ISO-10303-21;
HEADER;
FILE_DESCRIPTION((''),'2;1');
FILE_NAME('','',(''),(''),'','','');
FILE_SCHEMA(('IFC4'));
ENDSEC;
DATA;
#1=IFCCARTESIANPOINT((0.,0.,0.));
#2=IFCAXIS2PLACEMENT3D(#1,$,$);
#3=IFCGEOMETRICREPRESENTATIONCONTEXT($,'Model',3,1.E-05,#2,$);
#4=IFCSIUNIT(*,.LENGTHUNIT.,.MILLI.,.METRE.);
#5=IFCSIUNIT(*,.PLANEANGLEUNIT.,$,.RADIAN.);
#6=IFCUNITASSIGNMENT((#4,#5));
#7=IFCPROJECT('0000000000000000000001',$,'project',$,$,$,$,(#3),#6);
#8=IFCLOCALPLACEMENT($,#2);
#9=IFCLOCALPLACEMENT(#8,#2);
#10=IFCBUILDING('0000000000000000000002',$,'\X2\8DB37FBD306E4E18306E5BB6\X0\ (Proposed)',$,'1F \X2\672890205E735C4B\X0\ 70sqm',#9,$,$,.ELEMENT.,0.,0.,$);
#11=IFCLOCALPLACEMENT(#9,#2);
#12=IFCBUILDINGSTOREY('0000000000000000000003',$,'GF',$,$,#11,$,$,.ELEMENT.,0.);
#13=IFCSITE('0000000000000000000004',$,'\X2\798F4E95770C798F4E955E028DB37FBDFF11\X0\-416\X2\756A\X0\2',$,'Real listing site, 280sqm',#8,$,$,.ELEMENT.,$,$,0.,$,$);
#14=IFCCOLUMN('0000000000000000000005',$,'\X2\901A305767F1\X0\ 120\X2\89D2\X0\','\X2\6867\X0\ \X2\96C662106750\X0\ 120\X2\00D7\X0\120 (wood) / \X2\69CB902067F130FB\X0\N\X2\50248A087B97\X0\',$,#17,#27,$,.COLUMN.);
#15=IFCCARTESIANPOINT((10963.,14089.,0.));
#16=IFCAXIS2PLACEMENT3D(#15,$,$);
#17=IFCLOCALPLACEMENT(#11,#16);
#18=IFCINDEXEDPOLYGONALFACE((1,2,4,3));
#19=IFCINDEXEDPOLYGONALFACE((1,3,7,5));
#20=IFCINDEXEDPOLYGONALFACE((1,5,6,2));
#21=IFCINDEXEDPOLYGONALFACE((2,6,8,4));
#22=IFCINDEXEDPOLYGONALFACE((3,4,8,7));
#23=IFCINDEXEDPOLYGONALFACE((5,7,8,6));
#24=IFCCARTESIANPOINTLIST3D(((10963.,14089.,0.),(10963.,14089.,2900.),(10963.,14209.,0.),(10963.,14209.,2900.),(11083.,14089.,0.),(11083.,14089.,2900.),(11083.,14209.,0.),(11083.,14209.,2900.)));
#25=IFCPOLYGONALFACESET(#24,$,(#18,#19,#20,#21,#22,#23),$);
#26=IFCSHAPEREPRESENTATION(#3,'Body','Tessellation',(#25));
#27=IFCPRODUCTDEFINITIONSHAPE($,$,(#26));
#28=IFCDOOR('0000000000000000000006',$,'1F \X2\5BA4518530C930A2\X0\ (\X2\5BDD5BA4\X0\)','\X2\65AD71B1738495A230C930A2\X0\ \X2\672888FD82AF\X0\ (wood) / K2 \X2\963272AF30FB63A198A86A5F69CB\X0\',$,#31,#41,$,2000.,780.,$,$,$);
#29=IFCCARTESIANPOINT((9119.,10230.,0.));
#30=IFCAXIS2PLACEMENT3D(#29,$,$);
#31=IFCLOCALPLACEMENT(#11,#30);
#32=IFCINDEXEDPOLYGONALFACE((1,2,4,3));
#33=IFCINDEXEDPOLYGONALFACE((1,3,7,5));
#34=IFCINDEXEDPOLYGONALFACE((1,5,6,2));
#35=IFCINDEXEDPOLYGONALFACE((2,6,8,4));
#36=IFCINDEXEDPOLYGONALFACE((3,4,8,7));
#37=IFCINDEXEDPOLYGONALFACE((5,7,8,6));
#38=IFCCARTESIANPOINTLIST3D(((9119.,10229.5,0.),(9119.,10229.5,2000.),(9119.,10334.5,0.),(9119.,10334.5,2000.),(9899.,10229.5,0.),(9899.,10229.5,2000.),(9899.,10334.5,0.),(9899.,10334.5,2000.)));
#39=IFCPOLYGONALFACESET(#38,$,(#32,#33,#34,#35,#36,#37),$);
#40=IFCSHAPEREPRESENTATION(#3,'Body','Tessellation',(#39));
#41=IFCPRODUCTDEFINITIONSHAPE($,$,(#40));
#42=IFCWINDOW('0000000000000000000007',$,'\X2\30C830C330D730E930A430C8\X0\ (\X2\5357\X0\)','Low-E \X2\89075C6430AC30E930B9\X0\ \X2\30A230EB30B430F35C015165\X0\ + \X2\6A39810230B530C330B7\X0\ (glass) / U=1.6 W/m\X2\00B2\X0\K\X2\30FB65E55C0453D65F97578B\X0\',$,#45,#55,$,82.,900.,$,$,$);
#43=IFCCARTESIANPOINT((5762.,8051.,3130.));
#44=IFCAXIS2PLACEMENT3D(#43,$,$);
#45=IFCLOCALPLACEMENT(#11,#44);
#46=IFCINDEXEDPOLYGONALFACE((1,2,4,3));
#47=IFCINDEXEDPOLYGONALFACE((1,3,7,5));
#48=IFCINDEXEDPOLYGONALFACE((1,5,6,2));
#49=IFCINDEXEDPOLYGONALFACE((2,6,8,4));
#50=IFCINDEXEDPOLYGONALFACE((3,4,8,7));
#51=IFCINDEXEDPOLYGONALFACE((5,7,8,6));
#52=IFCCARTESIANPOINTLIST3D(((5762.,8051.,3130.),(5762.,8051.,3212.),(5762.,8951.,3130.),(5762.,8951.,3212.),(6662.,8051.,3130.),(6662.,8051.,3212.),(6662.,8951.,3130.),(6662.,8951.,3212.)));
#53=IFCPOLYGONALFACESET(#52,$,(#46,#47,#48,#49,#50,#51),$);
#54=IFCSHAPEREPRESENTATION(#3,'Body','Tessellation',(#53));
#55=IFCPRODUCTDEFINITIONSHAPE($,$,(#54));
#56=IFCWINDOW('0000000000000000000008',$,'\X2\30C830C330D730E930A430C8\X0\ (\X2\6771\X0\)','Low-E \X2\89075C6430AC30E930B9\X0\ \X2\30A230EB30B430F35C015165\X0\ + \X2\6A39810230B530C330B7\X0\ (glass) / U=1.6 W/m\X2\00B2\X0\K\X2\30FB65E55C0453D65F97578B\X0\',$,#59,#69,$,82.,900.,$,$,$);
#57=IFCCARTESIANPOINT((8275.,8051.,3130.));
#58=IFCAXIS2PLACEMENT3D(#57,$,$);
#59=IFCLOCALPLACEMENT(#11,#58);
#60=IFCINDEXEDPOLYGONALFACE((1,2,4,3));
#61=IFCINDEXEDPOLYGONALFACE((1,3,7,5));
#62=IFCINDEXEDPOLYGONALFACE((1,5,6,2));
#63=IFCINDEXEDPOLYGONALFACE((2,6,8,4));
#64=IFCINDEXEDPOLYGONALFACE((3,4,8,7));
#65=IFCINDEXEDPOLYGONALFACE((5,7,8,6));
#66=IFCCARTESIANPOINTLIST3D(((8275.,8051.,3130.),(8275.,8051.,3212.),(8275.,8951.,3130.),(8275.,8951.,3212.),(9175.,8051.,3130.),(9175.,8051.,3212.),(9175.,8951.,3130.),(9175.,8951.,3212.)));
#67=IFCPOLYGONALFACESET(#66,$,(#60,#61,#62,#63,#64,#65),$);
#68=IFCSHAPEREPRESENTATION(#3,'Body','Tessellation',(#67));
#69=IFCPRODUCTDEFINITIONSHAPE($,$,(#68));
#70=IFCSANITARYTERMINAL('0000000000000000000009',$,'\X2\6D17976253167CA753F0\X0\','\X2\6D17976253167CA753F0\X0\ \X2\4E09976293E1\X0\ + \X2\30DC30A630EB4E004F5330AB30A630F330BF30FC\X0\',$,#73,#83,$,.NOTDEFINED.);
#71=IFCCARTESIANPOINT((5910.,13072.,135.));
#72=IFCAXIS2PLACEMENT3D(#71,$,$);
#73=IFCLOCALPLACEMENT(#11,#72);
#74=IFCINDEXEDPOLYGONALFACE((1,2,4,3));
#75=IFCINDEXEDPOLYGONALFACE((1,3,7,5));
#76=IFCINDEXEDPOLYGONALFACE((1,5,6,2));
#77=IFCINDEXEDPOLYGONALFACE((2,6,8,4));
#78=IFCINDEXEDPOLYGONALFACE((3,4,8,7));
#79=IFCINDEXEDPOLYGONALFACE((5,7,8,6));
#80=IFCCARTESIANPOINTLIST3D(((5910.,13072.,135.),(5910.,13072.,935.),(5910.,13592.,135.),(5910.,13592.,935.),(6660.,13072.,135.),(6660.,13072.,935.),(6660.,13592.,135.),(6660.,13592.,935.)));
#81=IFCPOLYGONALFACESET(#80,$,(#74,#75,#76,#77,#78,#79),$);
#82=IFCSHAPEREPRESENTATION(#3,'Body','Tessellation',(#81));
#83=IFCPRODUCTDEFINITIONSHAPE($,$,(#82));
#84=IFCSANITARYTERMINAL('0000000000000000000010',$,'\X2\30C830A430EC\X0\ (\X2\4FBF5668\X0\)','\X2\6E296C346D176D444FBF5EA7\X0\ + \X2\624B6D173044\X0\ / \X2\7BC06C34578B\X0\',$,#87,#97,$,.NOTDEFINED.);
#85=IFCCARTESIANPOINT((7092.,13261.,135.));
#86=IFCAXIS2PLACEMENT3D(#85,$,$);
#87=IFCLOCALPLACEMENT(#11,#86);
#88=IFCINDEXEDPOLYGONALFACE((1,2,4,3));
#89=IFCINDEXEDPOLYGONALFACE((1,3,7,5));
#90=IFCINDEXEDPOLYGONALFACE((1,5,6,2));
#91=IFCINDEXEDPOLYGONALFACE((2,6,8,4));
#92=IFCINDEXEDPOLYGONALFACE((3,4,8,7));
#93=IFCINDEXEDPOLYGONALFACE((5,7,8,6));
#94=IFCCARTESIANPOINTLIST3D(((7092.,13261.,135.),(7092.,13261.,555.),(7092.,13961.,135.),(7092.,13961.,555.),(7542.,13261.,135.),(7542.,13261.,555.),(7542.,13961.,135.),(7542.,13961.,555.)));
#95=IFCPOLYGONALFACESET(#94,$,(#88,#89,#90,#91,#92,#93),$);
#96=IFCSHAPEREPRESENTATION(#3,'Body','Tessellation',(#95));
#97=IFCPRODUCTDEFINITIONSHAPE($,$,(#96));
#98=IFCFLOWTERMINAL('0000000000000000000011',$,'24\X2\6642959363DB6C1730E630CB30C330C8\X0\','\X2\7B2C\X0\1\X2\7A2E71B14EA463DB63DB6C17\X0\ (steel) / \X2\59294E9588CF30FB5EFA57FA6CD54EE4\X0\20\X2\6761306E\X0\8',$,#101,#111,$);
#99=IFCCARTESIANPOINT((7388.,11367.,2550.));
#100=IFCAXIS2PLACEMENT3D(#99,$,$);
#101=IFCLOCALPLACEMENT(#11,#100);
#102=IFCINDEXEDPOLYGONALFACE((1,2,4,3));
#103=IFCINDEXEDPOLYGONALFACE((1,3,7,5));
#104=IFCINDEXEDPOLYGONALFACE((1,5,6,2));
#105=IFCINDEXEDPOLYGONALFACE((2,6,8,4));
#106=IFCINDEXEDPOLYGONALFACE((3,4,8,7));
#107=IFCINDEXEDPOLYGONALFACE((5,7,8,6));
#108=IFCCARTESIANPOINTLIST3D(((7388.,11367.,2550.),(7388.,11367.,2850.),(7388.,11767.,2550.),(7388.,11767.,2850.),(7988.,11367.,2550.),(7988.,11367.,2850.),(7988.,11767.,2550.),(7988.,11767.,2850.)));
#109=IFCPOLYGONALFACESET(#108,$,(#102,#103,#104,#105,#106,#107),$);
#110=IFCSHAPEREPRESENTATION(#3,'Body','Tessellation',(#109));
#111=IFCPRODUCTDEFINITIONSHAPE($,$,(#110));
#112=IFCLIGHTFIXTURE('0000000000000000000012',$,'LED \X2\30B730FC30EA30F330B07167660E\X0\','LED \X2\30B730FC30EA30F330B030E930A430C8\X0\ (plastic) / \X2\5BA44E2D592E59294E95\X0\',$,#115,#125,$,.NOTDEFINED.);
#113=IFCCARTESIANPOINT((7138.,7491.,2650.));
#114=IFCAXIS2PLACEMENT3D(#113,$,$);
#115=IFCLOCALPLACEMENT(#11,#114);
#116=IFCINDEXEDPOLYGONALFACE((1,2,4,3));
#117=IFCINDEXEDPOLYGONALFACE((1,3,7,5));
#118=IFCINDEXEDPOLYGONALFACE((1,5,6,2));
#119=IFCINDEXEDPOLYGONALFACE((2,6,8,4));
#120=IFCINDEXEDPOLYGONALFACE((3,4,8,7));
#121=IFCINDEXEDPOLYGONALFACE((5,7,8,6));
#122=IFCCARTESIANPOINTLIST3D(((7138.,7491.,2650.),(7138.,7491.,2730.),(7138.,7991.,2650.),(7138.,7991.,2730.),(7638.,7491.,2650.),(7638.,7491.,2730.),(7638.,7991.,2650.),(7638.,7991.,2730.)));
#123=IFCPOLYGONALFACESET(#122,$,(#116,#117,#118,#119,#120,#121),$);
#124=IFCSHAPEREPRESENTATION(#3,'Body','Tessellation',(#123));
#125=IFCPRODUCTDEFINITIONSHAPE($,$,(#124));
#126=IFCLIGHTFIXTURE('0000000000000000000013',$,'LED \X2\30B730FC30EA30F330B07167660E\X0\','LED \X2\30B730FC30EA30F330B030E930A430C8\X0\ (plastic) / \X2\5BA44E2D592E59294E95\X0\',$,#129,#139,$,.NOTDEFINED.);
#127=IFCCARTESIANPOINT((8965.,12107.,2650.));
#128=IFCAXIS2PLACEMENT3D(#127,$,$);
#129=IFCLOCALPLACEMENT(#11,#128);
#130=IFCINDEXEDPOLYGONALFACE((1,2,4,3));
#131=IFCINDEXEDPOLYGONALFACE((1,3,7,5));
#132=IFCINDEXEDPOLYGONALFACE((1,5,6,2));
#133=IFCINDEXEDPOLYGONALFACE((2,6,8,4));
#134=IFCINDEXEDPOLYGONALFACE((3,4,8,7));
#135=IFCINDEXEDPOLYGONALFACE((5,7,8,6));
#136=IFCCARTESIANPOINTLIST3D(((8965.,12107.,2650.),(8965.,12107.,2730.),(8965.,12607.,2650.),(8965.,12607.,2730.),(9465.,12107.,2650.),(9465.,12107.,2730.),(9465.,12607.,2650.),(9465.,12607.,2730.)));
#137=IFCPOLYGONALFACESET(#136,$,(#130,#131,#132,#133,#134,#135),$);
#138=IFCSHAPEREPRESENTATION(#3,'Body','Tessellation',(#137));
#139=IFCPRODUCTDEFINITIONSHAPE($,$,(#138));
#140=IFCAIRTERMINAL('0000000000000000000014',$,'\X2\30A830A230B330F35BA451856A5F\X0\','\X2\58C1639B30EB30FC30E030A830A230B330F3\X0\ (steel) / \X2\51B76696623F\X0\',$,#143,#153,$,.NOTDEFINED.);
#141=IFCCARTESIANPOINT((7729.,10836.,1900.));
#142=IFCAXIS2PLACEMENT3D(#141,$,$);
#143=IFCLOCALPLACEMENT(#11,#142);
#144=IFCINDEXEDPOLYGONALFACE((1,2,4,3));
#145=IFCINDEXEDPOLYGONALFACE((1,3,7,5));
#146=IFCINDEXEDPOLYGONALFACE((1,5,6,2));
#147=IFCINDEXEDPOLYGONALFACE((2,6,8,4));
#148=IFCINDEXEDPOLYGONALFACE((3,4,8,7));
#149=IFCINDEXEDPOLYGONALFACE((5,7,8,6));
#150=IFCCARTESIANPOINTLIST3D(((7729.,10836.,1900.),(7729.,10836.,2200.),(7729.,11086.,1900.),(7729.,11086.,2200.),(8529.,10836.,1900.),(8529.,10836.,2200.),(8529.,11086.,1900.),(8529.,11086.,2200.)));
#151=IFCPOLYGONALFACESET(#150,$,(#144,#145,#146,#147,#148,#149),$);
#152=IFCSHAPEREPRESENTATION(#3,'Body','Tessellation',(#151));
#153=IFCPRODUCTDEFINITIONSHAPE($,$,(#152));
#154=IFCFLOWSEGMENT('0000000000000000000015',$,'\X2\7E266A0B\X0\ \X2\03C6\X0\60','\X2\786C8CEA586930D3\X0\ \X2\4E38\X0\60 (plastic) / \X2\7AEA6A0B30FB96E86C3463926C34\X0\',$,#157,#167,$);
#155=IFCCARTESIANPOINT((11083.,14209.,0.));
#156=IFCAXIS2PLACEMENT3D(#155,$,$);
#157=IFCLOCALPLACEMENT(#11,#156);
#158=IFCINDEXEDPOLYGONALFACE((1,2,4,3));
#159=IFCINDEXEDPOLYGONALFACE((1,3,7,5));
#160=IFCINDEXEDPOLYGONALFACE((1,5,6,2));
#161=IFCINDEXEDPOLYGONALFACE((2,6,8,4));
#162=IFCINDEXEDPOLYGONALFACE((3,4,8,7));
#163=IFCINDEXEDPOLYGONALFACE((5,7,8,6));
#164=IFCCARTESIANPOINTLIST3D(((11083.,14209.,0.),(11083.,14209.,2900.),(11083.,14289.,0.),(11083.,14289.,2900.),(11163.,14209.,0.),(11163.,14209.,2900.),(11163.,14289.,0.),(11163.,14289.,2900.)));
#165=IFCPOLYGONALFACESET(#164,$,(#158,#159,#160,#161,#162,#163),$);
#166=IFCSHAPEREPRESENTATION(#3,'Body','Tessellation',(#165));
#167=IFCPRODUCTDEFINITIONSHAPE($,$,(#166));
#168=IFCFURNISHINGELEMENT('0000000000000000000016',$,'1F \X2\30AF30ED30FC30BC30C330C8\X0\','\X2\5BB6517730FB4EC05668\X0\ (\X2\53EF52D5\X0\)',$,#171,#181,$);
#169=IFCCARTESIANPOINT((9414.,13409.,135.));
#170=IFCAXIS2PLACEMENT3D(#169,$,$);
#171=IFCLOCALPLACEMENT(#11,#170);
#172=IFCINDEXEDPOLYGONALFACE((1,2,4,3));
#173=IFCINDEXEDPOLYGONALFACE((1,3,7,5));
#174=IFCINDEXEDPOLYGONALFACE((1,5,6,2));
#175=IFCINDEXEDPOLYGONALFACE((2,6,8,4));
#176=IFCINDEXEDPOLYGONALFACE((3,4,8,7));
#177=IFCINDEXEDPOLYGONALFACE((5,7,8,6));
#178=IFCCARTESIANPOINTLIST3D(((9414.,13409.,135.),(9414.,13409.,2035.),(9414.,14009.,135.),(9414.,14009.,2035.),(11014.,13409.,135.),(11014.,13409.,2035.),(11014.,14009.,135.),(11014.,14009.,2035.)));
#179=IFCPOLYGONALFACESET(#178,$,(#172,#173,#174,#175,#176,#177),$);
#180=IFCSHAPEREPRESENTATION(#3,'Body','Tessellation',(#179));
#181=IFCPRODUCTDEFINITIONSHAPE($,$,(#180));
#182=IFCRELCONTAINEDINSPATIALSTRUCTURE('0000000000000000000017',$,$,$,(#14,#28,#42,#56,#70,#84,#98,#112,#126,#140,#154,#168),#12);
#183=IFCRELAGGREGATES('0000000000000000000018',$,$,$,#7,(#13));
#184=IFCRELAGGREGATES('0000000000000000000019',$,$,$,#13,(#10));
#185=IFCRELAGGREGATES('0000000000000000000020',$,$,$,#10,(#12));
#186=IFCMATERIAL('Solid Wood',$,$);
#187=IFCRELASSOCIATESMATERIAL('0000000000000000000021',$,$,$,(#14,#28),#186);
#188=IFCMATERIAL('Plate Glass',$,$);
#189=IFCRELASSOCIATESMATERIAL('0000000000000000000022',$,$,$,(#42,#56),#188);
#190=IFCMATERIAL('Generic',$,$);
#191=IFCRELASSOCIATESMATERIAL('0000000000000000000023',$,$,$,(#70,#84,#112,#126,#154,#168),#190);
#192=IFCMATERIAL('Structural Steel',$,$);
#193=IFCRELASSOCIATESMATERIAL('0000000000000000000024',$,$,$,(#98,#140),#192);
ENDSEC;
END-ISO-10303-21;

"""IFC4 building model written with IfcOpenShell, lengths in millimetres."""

from ifc_helpers import new_model, si_unit, frame, frame_2d, origin, place, context, project, spatial, rectangle, extrude, material, element, save


model = new_model("IFC4")

# Units and contexts
model_context = context("Model", 3, precision=1e-05, world=origin())
ifc_project = project(units=[si_unit("LENGTHUNIT", "METRE", prefix="MILLI"), si_unit("PLANEANGLEUNIT", "RADIAN")], contexts=[model_context])

# Site, building, storey
site_placement = place(None, origin())
site = spatial("IfcSite", under=ifc_project, at=site_placement, Name="福井県福井市足羽１-416番2", ObjectType="Real listing site, 280sqm", CompositionType="ELEMENT", RefElevation=0.0)
building_placement = place(site_placement, origin())
building = spatial("IfcBuilding", under=site, at=building_placement, Name="足羽の丘の家 (Proposed)", ObjectType="1F 木造平屋 70sqm", CompositionType="ELEMENT", ElevationOfRefHeight=0.0, ElevationOfTerrain=0.0)
storey_placement = place(building_placement, origin())
storey = spatial("IfcBuildingStorey", under=building, at=storey_placement, Name="GF", CompositionType="ELEMENT", Elevation=0.0)

# Column
ifc_material_1 = material(Name="Solid Wood")
column_1_placement = place(storey_placement, frame((10963.0, 14089.0, 0.0)))
element("IfcColumn", 1, at=column_1_placement, inside=storey, material=ifc_material_1, Name="通し柱 120角", Description="桧 集成材 120×120 (wood) / 構造柱・N値計算", PredefinedType="COLUMN", context=model_context, shape_type="SweptSolid", body=[
    extrude(rectangle(XDim=120.0, YDim=120.0, at=frame_2d((60.0, 60.0))), frame((10963.0, 14089.0, 0.0)), (0.0, 0.0, 1.0), 2900.0),
])

# Door
door_placement = place(storey_placement, frame((9119.0, 10230.0, 0.0)))
element("IfcDoor", 2, at=door_placement, inside=storey, material=ifc_material_1, Name="1F 室内ドア (寝室)", Description="断熱玄関ドア 木製芯 (wood) / K2 防犯・採風機構", OverallHeight=2000.0, OverallWidth=780.0, context=model_context, shape_type="SweptSolid", body=[
    extrude(rectangle(XDim=780.0, YDim=105.0, at=frame_2d((390.0, 52.0))), frame((9119.0, 10230.0, 0.0)), (0.0, 0.0, 1.0), 2000.0),
])

# Windows
ifc_material_2 = material(Name="Plate Glass")
window_1_placement = place(storey_placement, frame((5762.0, 8051.0, 3130.0)))
element("IfcWindow", 3, at=window_1_placement, inside=storey, material=ifc_material_2, Name="トップライト (南)", Description="Low-E 複層ガラス アルゴン封入 + 樹脂サッシ (glass) / U=1.6 W/m²K・日射取得型", OverallHeight=82.0, OverallWidth=900.0, context=model_context, shape_type="SweptSolid", body=[
    extrude(rectangle(XDim=900.0, YDim=900.0, at=frame_2d((450.0, 450.0))), frame((5762.0, 8051.0, 3130.0)), (0.0, 0.0, 1.0), 82.0),
])
window_2_placement = place(storey_placement, frame((8275.0, 8051.0, 3130.0)))
element("IfcWindow", 4, at=window_2_placement, inside=storey, material=ifc_material_2, Name="トップライト (東)", Description="Low-E 複層ガラス アルゴン封入 + 樹脂サッシ (glass) / U=1.6 W/m²K・日射取得型", OverallHeight=82.0, OverallWidth=900.0, context=model_context, shape_type="SweptSolid", body=[
    extrude(rectangle(XDim=900.0, YDim=900.0, at=frame_2d((450.0, 450.0))), frame((8275.0, 8051.0, 3130.0)), (0.0, 0.0, 1.0), 82.0),
])

# Sanitary terminals
ifc_material_3 = material(Name="Generic")
sanitary_terminal_1_placement = place(storey_placement, frame((5910.0, 13072.0, 135.0)))
element("IfcSanitaryTerminal", 5, at=sanitary_terminal_1_placement, inside=storey, material=ifc_material_3, Name="洗面化粧台", Description="洗面化粧台 三面鏡 + ボウル一体カウンター", PredefinedType="NOTDEFINED", context=model_context, shape_type="SweptSolid", body=[
    extrude(rectangle(XDim=750.0, YDim=520.0, at=frame_2d((375.0, 260.0))), frame((5910.0, 13072.0, 135.0)), (0.0, 0.0, 1.0), 800.0),
])
sanitary_terminal_2_placement = place(storey_placement, frame((7092.0, 13261.0, 135.0)))
element("IfcSanitaryTerminal", 6, at=sanitary_terminal_2_placement, inside=storey, material=ifc_material_3, Name="トイレ (便器)", Description="温水洗浄便座 + 手洗い / 節水型", PredefinedType="NOTDEFINED", context=model_context, shape_type="SweptSolid", body=[
    extrude(rectangle(XDim=450.0, YDim=700.0, at=frame_2d((225.0, 350.0))), frame((7092.0, 13261.0, 135.0)), (0.0, 0.0, 1.0), 420.0),
])

# Flow terminal
ifc_material_4 = material(Name="Structural Steel")
flow_terminal_placement = place(storey_placement, frame((7388.0, 11367.0, 2550.0)))
element("IfcFlowTerminal", 7, at=flow_terminal_placement, inside=storey, material=ifc_material_4, Name="24時間換気ユニット", Description="第1種熱交換換気 (steel) / 天井裏・建基法令20条の8", context=model_context, shape_type="SweptSolid", body=[
    extrude(rectangle(XDim=600.0, YDim=400.0, at=frame_2d((300.0, 200.0))), frame((7388.0, 11367.0, 2550.0)), (0.0, 0.0, 1.0), 300.0),
])

# Light fixtures
light_fixture_1_placement = place(storey_placement, frame((7138.0, 7491.0, 2650.0)))
element("IfcLightFixture", 8, at=light_fixture_1_placement, inside=storey, material=ifc_material_3, Name="LED シーリング照明", Description="LED シーリングライト (plastic) / 室中央天井", PredefinedType="NOTDEFINED", context=model_context, shape_type="SweptSolid", body=[
    extrude(rectangle(XDim=500.0, YDim=500.0, at=frame_2d((250.0, 250.0))), frame((7138.0, 7491.0, 2650.0)), (0.0, 0.0, 1.0), 80.0),
])
light_fixture_2_placement = place(storey_placement, frame((8965.0, 12107.0, 2650.0)))
element("IfcLightFixture", 9, at=light_fixture_2_placement, inside=storey, material=ifc_material_3, Name="LED シーリング照明", Description="LED シーリングライト (plastic) / 室中央天井", PredefinedType="NOTDEFINED", context=model_context, shape_type="SweptSolid", body=[
    extrude(rectangle(XDim=500.0, YDim=500.0, at=frame_2d((250.0, 250.0))), frame((8965.0, 12107.0, 2650.0)), (0.0, 0.0, 1.0), 80.0),
])

# Air terminal
air_terminal_placement = place(storey_placement, frame((7729.0, 10836.0, 1900.0)))
element("IfcAirTerminal", 10, at=air_terminal_placement, inside=storey, material=ifc_material_4, Name="エアコン室内機", Description="壁掛ルームエアコン (steel) / 冷暖房", PredefinedType="NOTDEFINED", context=model_context, shape_type="SweptSolid", body=[
    extrude(rectangle(XDim=800.0, YDim=250.0, at=frame_2d((400.0, 125.0))), frame((7729.0, 10836.0, 1900.0)), (0.0, 0.0, 1.0), 300.0),
])

# Flow segment
flow_segment_placement = place(storey_placement, frame((11083.0, 14209.0, 0.0)))
element("IfcFlowSegment", 11, at=flow_segment_placement, inside=storey, material=ifc_material_3, Name="縦樋 φ60", Description="硬質塩ビ 丸60 (plastic) / 竪樋・雨水排水", context=model_context, shape_type="SweptSolid", body=[
    extrude(rectangle(XDim=80.0, YDim=80.0, at=frame_2d((40.0, 40.0))), frame((11083.0, 14209.0, 0.0)), (0.0, 0.0, 1.0), 2900.0),
])

# Furnishing element
furnishing_placement = place(storey_placement, frame((9414.0, 13409.0, 135.0)))
element("IfcFurnishingElement", 12, at=furnishing_placement, inside=storey, material=ifc_material_3, Name="1F クローゼット", Description="家具・什器 (可動)", context=model_context, shape_type="SweptSolid", body=[
    extrude(rectangle(XDim=1600.0, YDim=600.0, at=frame_2d((800.0, 300.0))), frame((9414.0, 13409.0, 135.0)), (0.0, 0.0, 1.0), 1900.0),
])

save(model, "model.ifc")
